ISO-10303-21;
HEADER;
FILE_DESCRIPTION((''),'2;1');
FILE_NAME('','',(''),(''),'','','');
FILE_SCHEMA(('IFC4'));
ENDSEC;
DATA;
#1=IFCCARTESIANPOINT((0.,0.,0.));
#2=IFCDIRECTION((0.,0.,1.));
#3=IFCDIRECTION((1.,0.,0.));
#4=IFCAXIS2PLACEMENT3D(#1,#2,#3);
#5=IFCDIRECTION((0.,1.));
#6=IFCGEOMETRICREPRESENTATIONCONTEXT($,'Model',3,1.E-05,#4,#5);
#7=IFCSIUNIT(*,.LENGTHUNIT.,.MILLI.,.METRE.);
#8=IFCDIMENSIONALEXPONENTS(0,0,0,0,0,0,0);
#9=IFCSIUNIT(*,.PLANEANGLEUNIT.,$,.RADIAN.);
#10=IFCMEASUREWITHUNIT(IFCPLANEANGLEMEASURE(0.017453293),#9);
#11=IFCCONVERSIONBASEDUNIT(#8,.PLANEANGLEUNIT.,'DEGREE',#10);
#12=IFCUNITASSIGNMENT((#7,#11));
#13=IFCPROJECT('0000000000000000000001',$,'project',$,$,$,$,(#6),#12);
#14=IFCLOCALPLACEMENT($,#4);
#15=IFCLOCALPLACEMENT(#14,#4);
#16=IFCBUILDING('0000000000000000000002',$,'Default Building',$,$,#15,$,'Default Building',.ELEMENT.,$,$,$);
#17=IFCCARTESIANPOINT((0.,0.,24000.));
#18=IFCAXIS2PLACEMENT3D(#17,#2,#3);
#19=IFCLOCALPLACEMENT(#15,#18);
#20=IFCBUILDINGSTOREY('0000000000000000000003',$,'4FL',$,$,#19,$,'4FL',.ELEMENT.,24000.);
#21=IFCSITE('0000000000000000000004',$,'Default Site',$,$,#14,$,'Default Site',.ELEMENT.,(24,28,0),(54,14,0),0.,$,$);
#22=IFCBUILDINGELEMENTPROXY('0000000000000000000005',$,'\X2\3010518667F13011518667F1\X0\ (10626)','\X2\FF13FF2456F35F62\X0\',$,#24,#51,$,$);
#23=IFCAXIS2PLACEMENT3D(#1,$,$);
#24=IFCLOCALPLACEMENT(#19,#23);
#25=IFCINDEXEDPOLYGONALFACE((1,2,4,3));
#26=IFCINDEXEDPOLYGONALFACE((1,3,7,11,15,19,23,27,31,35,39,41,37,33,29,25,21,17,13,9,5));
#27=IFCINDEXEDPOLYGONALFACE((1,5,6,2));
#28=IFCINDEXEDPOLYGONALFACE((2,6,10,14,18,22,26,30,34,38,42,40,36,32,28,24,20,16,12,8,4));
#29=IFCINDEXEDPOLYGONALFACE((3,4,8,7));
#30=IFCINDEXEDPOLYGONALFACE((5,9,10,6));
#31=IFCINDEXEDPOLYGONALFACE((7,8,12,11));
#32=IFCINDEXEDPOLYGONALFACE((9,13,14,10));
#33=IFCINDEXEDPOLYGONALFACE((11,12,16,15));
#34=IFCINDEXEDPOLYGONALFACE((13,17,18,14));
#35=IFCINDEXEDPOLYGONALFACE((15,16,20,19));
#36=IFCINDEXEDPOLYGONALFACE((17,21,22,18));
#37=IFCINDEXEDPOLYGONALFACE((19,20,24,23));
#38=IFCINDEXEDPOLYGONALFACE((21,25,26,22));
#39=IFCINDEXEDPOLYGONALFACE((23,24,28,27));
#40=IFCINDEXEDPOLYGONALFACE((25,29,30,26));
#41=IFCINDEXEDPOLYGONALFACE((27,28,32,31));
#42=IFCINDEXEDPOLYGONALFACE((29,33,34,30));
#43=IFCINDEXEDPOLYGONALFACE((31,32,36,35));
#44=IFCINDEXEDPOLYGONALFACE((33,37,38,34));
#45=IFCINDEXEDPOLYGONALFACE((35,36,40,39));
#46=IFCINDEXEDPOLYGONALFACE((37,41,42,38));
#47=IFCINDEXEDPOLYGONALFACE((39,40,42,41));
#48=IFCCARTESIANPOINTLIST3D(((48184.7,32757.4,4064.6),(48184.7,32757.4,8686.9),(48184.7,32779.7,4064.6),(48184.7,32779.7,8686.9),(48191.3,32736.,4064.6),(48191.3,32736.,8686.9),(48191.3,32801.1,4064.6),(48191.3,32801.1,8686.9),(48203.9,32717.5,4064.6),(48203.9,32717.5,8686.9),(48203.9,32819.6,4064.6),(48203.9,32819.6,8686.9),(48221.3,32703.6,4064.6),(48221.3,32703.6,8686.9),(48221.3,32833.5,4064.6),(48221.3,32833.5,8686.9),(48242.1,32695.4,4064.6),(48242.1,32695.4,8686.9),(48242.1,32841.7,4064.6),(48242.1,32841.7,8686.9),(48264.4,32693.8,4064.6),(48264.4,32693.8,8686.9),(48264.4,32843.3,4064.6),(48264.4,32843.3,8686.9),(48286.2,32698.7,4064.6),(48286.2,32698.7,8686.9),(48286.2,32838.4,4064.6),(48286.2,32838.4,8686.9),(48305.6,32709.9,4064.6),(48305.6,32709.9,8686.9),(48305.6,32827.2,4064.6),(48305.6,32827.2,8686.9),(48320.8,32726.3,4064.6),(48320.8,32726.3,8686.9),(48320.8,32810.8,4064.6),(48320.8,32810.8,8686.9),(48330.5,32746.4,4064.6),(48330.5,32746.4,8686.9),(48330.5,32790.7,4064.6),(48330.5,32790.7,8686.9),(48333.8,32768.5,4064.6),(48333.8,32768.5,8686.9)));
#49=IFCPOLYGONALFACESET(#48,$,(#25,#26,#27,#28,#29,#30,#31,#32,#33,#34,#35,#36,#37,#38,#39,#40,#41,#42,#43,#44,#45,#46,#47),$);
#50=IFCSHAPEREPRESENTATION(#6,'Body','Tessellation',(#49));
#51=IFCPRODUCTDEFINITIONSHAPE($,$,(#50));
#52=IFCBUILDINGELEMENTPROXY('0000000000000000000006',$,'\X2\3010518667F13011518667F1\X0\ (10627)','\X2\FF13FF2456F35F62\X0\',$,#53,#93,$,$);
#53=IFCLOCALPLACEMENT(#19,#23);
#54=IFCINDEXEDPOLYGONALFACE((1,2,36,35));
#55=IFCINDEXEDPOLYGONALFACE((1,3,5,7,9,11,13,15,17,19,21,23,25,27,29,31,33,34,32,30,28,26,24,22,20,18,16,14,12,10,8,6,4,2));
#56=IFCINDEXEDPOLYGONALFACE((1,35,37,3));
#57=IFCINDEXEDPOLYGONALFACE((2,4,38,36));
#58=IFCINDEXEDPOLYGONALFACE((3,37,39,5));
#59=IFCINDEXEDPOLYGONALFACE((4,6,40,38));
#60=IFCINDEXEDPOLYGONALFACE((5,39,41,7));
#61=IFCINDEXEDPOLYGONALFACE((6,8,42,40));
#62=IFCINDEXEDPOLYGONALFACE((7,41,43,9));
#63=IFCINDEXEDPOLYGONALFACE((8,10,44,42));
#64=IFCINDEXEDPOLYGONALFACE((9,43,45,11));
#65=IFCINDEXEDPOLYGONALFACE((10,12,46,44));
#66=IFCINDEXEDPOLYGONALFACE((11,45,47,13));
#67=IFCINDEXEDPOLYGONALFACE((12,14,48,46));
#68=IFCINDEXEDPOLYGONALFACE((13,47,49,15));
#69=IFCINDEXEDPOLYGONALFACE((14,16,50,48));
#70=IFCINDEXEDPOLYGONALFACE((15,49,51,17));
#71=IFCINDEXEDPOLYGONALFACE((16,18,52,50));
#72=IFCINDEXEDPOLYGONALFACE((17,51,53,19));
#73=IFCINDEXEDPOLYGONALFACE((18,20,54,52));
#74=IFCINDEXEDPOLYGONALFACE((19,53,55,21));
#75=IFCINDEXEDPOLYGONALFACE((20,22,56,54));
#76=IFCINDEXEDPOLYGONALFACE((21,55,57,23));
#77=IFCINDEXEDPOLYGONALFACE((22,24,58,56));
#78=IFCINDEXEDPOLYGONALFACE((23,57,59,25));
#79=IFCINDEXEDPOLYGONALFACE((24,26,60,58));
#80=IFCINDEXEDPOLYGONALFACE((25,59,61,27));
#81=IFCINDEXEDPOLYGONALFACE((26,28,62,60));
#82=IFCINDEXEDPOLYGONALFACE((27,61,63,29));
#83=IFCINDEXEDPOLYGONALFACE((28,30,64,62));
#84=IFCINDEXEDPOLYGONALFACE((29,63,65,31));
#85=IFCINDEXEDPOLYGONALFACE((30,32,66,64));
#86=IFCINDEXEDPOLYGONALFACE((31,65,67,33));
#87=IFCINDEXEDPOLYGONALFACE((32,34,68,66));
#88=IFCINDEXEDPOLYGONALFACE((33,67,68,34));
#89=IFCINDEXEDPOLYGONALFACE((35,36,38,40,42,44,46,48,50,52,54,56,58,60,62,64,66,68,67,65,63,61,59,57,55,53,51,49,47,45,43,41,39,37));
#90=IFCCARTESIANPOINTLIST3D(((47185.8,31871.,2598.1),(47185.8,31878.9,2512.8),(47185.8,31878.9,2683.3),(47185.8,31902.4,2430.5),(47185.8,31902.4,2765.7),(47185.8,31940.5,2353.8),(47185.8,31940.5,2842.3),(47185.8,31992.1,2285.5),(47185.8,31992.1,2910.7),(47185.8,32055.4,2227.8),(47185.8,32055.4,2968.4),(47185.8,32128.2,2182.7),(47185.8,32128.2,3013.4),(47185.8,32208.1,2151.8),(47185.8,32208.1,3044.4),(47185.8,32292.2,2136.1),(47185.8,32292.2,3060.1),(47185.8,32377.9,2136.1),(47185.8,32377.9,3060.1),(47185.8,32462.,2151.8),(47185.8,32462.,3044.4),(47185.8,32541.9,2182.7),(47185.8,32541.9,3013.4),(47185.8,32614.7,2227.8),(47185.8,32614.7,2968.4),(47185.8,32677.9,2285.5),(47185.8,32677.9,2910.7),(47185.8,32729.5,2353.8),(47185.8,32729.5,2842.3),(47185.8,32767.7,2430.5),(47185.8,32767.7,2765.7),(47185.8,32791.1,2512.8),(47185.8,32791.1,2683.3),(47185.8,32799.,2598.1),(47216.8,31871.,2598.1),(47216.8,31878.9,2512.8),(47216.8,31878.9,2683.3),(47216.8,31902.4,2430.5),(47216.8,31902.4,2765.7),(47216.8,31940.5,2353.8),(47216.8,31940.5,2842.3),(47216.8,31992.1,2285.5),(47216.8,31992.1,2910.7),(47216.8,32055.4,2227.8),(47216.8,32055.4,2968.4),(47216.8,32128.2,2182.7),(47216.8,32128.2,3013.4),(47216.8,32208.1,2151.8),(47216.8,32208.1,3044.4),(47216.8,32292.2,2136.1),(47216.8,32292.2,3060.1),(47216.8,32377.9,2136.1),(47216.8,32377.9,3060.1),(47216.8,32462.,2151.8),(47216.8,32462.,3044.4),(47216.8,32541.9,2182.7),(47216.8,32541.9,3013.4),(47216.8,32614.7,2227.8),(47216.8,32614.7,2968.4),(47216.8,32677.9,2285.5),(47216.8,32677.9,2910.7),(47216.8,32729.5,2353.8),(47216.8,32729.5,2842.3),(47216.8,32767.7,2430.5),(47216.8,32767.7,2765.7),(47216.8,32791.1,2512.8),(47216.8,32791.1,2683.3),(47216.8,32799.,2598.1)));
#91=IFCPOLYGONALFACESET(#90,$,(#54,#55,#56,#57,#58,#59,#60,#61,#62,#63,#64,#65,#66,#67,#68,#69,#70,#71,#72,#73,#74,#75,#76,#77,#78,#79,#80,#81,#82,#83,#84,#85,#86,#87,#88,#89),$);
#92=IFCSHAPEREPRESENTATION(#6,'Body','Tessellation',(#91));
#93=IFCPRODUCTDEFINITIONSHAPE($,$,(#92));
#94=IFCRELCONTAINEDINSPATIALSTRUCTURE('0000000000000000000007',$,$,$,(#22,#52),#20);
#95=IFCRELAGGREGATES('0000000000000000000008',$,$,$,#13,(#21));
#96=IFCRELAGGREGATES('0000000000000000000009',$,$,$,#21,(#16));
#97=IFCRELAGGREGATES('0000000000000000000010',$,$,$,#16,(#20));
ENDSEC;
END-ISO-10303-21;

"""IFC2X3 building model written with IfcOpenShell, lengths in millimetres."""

from ifc_helpers import new_model, entity, si_unit, converted_unit, direction, frame, origin_with_axes, origin_2d_with_axis, place, context, project, spatial, circle, extrude, source, transform, mapped, element, save


model = new_model("IFC2X3")

# Units and contexts
model_context = context("Model", 3, precision=1e-05, world=origin_with_axes(), true_north=direction((0.0, 1.0)))
ifc_project = project(units=[si_unit("LENGTHUNIT", "METRE", prefix="MILLI"), converted_unit("PLANEANGLEUNIT", "DEGREE", entity("IfcPlaneAngleMeasure", 0.017453293), si_unit("PLANEANGLEUNIT", "RADIAN"), dimensions=[0, 0, 0, 0, 0, 0, 0])], contexts=[model_context])

# Site, building, storey
site_placement = place(None, origin_with_axes())
site = spatial("IfcSite", under=ifc_project, at=site_placement, Name="Default Site", LongName="Default Site", CompositionType="ELEMENT", RefLatitude=(24, 28, 0), RefLongitude=(54, 14, 0), RefElevation=0.0)
building_placement = place(site_placement, origin_with_axes())
building = spatial("IfcBuilding", under=site, at=building_placement, Name="Default Building", LongName="Default Building", CompositionType="ELEMENT")
storey_placement = place(building_placement, frame((0.0, 0.0, 24000.0), z_axis=(0.0, 0.0, 1.0), x_axis=(1.0, 0.0, 0.0)))
storey = spatial("IfcBuildingStorey", under=building, at=storey_placement, Name="4FL", LongName="4FL", CompositionType="ELEMENT", Elevation=24000.0)

# Building element proxies
shared_shape_1 = source(origin_with_axes(), model_context, "Body", "SweptSolid", [
    extrude(circle(Radius=75.0, at=origin_2d_with_axis()), origin_with_axes(), (0.0, 0.0, 1.0), 4622.4),
])
proxy_1_placement = place(storey_placement, frame((48258.8, 32768.5, 4064.6), z_axis=(0.0, 0.0, 1.0), x_axis=(1.0, 0.0, 0.0)))
element("IfcBuildingElementProxy", 1, at=proxy_1_placement, inside=storey, Name="【円柱】円柱 (10626)", Description="３Ｄ図形", context=model_context, shape_type="MappedRepresentation", body=[
    mapped(shared_shape_1, transform((0.0, 0.0, 0.0))),
])
shared_shape_2 = source(origin_with_axes(), model_context, "Body", "SweptSolid", [
    extrude(circle(Radius=464.0, at=origin_2d_with_axis()), frame((0.0, 0.0, 0.0), z_axis=(0.0, 0.0, 1.0), x_axis=(1.0, 0.0, 0.0)), (0.0, 0.0, 1.0), 31.0),
])
proxy_2_placement = place(storey_placement, frame((47185.8, 32335.0, 2598.1), z_axis=(1.0, 0.0, 0.0), x_axis=(0.0, -1.0, 0.0)))
element("IfcBuildingElementProxy", 2, at=proxy_2_placement, inside=storey, Name="【円柱】円柱 (10627)", Description="３Ｄ図形", context=model_context, shape_type="MappedRepresentation", body=[
    mapped(shared_shape_2, transform((0.0, 0.0, 0.0))),
])

save(model, "model.ifc")
